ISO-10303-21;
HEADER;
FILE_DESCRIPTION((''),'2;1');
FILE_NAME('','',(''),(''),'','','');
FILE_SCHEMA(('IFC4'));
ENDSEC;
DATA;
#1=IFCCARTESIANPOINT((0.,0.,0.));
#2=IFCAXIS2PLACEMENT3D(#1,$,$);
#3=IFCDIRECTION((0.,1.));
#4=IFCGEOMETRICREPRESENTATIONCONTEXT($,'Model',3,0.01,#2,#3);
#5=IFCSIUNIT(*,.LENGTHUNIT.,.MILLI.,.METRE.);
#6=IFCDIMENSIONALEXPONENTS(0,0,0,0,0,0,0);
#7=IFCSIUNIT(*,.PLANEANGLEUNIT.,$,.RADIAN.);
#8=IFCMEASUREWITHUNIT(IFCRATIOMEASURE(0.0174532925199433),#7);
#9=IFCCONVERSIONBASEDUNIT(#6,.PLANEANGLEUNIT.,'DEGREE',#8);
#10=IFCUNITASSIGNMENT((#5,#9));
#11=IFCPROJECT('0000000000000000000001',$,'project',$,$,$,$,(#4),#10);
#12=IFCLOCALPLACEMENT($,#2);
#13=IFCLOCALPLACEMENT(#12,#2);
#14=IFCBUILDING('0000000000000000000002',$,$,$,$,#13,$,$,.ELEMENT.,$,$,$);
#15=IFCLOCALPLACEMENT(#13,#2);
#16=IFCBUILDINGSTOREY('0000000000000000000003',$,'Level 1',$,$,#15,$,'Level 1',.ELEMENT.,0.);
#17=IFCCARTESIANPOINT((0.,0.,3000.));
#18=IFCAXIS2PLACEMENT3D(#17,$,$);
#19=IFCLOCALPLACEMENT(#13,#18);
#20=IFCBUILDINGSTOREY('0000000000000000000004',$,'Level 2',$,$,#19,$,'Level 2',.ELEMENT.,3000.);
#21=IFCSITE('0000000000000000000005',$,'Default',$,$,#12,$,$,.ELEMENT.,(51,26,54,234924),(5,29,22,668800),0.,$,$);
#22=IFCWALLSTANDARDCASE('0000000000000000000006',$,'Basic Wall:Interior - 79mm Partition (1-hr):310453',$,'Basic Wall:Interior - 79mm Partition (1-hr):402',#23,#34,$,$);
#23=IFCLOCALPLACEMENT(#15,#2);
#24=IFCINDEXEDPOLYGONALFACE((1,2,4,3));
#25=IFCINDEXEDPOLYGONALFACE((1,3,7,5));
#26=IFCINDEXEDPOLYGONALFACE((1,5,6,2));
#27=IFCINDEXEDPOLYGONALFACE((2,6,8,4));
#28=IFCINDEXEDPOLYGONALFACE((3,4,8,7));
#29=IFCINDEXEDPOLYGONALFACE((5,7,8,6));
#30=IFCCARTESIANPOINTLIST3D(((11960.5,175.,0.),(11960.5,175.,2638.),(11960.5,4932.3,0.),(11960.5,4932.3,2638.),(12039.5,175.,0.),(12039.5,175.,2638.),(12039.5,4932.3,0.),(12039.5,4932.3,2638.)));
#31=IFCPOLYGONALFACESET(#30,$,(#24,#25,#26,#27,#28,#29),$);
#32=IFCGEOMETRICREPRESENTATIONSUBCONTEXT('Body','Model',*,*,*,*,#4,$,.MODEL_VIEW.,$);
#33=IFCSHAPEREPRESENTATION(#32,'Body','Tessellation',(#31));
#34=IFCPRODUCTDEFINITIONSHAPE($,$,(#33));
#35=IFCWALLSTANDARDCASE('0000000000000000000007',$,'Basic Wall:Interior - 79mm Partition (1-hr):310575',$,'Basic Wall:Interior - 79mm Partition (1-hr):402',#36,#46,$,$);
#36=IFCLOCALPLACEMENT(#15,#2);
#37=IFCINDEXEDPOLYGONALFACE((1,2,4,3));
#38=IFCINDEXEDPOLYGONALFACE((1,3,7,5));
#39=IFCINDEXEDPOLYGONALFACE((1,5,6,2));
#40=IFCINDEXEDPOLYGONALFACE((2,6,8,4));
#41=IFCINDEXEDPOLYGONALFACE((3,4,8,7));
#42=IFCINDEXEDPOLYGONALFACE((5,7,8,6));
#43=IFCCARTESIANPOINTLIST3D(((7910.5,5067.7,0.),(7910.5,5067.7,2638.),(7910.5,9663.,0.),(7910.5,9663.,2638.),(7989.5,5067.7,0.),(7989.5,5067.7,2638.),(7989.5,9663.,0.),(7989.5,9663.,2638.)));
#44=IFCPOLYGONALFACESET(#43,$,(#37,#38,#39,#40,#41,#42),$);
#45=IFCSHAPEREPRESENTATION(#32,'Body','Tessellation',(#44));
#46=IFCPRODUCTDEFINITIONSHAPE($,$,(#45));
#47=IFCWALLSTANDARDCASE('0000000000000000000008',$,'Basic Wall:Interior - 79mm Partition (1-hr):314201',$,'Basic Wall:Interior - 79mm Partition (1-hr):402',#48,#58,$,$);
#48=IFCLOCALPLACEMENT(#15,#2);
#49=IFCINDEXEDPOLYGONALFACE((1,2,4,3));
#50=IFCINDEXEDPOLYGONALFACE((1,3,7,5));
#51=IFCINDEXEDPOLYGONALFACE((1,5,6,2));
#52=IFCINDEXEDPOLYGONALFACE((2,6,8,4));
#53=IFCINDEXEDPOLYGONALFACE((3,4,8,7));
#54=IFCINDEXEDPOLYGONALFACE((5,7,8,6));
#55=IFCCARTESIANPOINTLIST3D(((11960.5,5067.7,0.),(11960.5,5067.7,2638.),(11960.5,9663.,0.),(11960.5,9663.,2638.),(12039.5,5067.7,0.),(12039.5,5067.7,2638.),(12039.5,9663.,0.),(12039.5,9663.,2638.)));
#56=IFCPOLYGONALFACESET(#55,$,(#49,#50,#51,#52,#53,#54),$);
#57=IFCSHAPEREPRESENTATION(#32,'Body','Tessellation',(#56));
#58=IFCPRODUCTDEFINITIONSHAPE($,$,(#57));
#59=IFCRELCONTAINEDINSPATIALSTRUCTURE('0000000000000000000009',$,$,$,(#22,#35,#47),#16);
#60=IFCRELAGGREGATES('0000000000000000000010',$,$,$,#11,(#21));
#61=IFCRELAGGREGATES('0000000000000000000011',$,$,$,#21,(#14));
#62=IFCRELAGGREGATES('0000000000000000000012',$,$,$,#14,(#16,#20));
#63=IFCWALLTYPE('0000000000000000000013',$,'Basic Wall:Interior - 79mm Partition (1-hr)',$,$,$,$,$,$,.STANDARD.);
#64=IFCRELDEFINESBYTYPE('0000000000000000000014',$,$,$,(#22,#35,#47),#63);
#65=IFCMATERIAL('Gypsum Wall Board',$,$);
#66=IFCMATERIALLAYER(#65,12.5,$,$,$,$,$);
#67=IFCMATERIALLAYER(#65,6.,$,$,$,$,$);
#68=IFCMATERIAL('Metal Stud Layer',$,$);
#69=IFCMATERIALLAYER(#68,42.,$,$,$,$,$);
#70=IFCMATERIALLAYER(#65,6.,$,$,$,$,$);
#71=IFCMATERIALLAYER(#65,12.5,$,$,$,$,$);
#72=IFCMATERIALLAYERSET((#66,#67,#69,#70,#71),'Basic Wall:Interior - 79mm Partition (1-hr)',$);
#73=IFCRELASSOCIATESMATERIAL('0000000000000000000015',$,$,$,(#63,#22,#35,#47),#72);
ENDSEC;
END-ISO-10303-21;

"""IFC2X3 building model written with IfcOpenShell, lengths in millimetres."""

from ifc_helpers import new_model, entity, si_unit, converted_unit, direction, frame, frame_2d, origin, place, context, subcontext, project, spatial, polyline, rectangle, extrude, clip, bounded_halfspace, material, layer, layer_set, layer_usage, type_object, element, save


model = new_model("IFC2X3")

# Units and contexts
model_context = context("Model", 3, precision=0.01, world=origin(), true_north=direction((0.0, 1.0)))
body_context = subcontext(model_context, "Body", "Model", "MODEL_VIEW")
ifc_project = project(units=[si_unit("LENGTHUNIT", "METRE", prefix="MILLI"), converted_unit("PLANEANGLEUNIT", "DEGREE", entity("IfcRatioMeasure", 0.0174532925199433), si_unit("PLANEANGLEUNIT", "RADIAN"), dimensions=[0, 0, 0, 0, 0, 0, 0])], contexts=[model_context])

# Site, building, storey
site_placement = place(None, origin())
site = spatial("IfcSite", under=ifc_project, at=site_placement, Name="Default", CompositionType="ELEMENT", RefLatitude=(51, 26, 54, 234924), RefLongitude=(5, 29, 22, 668800), RefElevation=0.0)
building_placement = place(site_placement, origin())
building = spatial("IfcBuilding", under=site, at=building_placement, CompositionType="ELEMENT")
storey_1_placement = place(building_placement, origin())
storey_1 = spatial("IfcBuildingStorey", under=building, at=storey_1_placement, Name="Level 1", LongName="Level 1", CompositionType="ELEMENT", Elevation=0.0)

# Shared definitions
ifc_material_1 = material(Name="Metal Stud Layer")
ifc_material_2 = material(Name="Gypsum Wall Board")

# Shared definitions
storey_2_placement = place(building_placement, frame((0.0, 0.0, 3000.0)))
storey_2 = spatial("IfcBuildingStorey", under=building, at=storey_2_placement, Name="Level 2", LongName="Level 2", CompositionType="ELEMENT", Elevation=3000.0)

# Walls
ifc_layer_1 = layer(ifc_material_2, 12.5)
ifc_layer_2 = layer(ifc_material_2, 6.0)
ifc_layer_3 = layer(ifc_material_1, 42.0)
ifc_layer_4 = layer(ifc_material_2, 6.0)
ifc_layer_5 = layer(ifc_material_2, 12.5)
ifc_layer_set_1 = layer_set([ifc_layer_1, ifc_layer_2, ifc_layer_3, ifc_layer_4, ifc_layer_5], Name="Basic Wall:Interior - 79mm Partition (1-hr)")
ifc_layer_usage_1 = layer_usage(ifc_layer_set_1, "AXIS2", "NEGATIVE", 39.5)
wall_type_1 = type_object("IfcWallType", Name="Basic Wall:Interior - 79mm Partition (1-hr)", PredefinedType="STANDARD", material=ifc_layer_set_1)
wall_1_placement = place(storey_1_placement, frame((12000.0, 175.0, 0.0), z_axis=(0.0, 0.0, 1.0), x_axis=(0.0, 1.0, 0.0)))
element("IfcWallStandardCase", 1, at=wall_1_placement, inside=storey_1, type_object=wall_type_1, material=ifc_layer_usage_1, Name="Basic Wall:Interior - 79mm Partition (1-hr):310453", ObjectType="Basic Wall:Interior - 79mm Partition (1-hr):402", context=body_context, shape_type="Clipping", body=[
    clip(extrude(rectangle(XDim=4757.3, YDim=79.0, at=frame_2d((2378.6, 0.0), x_axis=(-1.0, 0.0))), origin(), (0.0, 0.0, 1.0), 2638.0), bounded_halfspace(frame((0.0, -39.5, 2638.0), z_axis=(0.0, 0.0, -1.0), x_axis=(0.0, 1.0, 0.0)), True, frame((0.0, -39.5, 2638.0)), polyline([(0.0, 0.0), (4757.3, 0.0), (4757.3, 79.0), (0.0, 79.0), (0.0, 0.0)]))),
])
ifc_layer_usage_2 = layer_usage(ifc_layer_set_1, "AXIS2", "NEGATIVE", 39.5)
wall_2_placement = place(storey_1_placement, frame((7950.0, 5067.7, 0.0), z_axis=(0.0, 0.0, 1.0), x_axis=(0.0, 1.0, 0.0)))
element("IfcWallStandardCase", 2, at=wall_2_placement, inside=storey_1, type_object=wall_type_1, material=ifc_layer_usage_2, Name="Basic Wall:Interior - 79mm Partition (1-hr):310575", ObjectType="Basic Wall:Interior - 79mm Partition (1-hr):402", context=body_context, shape_type="Clipping", body=[
    clip(extrude(rectangle(XDim=4595.3, YDim=79.0, at=frame_2d((2297.6, 0.0), x_axis=(-1.0, 0.0))), origin(), (0.0, 0.0, 1.0), 2638.0), bounded_halfspace(frame((0.0, -39.5, 2638.0), z_axis=(0.0, 0.0, -1.0), x_axis=(0.0, 1.0, 0.0)), True, frame((0.0, -39.5, 2638.0)), polyline([(0.0, 0.0), (4595.3, 0.0), (4595.3, 79.0), (0.0, 79.0), (0.0, 0.0)]))),
])
ifc_layer_usage_3 = layer_usage(ifc_layer_set_1, "AXIS2", "NEGATIVE", 39.5)
wall_3_placement = place(storey_1_placement, frame((12000.0, 9663.0, 0.0), z_axis=(0.0, 0.0, 1.0), x_axis=(0.0, -1.0, 0.0)))
element("IfcWallStandardCase", 3, at=wall_3_placement, inside=storey_1, type_object=wall_type_1, material=ifc_layer_usage_3, Name="Basic Wall:Interior - 79mm Partition (1-hr):314201", ObjectType="Basic Wall:Interior - 79mm Partition (1-hr):402", context=body_context, shape_type="Clipping", body=[
    clip(extrude(rectangle(XDim=4595.3, YDim=79.0, at=frame_2d((2297.6, 0.0), x_axis=(-1.0, 0.0))), origin(), (0.0, 0.0, 1.0), 2638.0), bounded_halfspace(frame((0.0, -39.5, 2638.0), z_axis=(0.0, 0.0, -1.0), x_axis=(0.0, -1.0, 0.0)), True, frame((0.0, -39.5, 2638.0)), polyline([(0.0, 0.0), (4595.3, 0.0), (4595.3, 79.0), (0.0, 79.0), (0.0, 0.0)]))),
])

save(model, "model.ifc")
